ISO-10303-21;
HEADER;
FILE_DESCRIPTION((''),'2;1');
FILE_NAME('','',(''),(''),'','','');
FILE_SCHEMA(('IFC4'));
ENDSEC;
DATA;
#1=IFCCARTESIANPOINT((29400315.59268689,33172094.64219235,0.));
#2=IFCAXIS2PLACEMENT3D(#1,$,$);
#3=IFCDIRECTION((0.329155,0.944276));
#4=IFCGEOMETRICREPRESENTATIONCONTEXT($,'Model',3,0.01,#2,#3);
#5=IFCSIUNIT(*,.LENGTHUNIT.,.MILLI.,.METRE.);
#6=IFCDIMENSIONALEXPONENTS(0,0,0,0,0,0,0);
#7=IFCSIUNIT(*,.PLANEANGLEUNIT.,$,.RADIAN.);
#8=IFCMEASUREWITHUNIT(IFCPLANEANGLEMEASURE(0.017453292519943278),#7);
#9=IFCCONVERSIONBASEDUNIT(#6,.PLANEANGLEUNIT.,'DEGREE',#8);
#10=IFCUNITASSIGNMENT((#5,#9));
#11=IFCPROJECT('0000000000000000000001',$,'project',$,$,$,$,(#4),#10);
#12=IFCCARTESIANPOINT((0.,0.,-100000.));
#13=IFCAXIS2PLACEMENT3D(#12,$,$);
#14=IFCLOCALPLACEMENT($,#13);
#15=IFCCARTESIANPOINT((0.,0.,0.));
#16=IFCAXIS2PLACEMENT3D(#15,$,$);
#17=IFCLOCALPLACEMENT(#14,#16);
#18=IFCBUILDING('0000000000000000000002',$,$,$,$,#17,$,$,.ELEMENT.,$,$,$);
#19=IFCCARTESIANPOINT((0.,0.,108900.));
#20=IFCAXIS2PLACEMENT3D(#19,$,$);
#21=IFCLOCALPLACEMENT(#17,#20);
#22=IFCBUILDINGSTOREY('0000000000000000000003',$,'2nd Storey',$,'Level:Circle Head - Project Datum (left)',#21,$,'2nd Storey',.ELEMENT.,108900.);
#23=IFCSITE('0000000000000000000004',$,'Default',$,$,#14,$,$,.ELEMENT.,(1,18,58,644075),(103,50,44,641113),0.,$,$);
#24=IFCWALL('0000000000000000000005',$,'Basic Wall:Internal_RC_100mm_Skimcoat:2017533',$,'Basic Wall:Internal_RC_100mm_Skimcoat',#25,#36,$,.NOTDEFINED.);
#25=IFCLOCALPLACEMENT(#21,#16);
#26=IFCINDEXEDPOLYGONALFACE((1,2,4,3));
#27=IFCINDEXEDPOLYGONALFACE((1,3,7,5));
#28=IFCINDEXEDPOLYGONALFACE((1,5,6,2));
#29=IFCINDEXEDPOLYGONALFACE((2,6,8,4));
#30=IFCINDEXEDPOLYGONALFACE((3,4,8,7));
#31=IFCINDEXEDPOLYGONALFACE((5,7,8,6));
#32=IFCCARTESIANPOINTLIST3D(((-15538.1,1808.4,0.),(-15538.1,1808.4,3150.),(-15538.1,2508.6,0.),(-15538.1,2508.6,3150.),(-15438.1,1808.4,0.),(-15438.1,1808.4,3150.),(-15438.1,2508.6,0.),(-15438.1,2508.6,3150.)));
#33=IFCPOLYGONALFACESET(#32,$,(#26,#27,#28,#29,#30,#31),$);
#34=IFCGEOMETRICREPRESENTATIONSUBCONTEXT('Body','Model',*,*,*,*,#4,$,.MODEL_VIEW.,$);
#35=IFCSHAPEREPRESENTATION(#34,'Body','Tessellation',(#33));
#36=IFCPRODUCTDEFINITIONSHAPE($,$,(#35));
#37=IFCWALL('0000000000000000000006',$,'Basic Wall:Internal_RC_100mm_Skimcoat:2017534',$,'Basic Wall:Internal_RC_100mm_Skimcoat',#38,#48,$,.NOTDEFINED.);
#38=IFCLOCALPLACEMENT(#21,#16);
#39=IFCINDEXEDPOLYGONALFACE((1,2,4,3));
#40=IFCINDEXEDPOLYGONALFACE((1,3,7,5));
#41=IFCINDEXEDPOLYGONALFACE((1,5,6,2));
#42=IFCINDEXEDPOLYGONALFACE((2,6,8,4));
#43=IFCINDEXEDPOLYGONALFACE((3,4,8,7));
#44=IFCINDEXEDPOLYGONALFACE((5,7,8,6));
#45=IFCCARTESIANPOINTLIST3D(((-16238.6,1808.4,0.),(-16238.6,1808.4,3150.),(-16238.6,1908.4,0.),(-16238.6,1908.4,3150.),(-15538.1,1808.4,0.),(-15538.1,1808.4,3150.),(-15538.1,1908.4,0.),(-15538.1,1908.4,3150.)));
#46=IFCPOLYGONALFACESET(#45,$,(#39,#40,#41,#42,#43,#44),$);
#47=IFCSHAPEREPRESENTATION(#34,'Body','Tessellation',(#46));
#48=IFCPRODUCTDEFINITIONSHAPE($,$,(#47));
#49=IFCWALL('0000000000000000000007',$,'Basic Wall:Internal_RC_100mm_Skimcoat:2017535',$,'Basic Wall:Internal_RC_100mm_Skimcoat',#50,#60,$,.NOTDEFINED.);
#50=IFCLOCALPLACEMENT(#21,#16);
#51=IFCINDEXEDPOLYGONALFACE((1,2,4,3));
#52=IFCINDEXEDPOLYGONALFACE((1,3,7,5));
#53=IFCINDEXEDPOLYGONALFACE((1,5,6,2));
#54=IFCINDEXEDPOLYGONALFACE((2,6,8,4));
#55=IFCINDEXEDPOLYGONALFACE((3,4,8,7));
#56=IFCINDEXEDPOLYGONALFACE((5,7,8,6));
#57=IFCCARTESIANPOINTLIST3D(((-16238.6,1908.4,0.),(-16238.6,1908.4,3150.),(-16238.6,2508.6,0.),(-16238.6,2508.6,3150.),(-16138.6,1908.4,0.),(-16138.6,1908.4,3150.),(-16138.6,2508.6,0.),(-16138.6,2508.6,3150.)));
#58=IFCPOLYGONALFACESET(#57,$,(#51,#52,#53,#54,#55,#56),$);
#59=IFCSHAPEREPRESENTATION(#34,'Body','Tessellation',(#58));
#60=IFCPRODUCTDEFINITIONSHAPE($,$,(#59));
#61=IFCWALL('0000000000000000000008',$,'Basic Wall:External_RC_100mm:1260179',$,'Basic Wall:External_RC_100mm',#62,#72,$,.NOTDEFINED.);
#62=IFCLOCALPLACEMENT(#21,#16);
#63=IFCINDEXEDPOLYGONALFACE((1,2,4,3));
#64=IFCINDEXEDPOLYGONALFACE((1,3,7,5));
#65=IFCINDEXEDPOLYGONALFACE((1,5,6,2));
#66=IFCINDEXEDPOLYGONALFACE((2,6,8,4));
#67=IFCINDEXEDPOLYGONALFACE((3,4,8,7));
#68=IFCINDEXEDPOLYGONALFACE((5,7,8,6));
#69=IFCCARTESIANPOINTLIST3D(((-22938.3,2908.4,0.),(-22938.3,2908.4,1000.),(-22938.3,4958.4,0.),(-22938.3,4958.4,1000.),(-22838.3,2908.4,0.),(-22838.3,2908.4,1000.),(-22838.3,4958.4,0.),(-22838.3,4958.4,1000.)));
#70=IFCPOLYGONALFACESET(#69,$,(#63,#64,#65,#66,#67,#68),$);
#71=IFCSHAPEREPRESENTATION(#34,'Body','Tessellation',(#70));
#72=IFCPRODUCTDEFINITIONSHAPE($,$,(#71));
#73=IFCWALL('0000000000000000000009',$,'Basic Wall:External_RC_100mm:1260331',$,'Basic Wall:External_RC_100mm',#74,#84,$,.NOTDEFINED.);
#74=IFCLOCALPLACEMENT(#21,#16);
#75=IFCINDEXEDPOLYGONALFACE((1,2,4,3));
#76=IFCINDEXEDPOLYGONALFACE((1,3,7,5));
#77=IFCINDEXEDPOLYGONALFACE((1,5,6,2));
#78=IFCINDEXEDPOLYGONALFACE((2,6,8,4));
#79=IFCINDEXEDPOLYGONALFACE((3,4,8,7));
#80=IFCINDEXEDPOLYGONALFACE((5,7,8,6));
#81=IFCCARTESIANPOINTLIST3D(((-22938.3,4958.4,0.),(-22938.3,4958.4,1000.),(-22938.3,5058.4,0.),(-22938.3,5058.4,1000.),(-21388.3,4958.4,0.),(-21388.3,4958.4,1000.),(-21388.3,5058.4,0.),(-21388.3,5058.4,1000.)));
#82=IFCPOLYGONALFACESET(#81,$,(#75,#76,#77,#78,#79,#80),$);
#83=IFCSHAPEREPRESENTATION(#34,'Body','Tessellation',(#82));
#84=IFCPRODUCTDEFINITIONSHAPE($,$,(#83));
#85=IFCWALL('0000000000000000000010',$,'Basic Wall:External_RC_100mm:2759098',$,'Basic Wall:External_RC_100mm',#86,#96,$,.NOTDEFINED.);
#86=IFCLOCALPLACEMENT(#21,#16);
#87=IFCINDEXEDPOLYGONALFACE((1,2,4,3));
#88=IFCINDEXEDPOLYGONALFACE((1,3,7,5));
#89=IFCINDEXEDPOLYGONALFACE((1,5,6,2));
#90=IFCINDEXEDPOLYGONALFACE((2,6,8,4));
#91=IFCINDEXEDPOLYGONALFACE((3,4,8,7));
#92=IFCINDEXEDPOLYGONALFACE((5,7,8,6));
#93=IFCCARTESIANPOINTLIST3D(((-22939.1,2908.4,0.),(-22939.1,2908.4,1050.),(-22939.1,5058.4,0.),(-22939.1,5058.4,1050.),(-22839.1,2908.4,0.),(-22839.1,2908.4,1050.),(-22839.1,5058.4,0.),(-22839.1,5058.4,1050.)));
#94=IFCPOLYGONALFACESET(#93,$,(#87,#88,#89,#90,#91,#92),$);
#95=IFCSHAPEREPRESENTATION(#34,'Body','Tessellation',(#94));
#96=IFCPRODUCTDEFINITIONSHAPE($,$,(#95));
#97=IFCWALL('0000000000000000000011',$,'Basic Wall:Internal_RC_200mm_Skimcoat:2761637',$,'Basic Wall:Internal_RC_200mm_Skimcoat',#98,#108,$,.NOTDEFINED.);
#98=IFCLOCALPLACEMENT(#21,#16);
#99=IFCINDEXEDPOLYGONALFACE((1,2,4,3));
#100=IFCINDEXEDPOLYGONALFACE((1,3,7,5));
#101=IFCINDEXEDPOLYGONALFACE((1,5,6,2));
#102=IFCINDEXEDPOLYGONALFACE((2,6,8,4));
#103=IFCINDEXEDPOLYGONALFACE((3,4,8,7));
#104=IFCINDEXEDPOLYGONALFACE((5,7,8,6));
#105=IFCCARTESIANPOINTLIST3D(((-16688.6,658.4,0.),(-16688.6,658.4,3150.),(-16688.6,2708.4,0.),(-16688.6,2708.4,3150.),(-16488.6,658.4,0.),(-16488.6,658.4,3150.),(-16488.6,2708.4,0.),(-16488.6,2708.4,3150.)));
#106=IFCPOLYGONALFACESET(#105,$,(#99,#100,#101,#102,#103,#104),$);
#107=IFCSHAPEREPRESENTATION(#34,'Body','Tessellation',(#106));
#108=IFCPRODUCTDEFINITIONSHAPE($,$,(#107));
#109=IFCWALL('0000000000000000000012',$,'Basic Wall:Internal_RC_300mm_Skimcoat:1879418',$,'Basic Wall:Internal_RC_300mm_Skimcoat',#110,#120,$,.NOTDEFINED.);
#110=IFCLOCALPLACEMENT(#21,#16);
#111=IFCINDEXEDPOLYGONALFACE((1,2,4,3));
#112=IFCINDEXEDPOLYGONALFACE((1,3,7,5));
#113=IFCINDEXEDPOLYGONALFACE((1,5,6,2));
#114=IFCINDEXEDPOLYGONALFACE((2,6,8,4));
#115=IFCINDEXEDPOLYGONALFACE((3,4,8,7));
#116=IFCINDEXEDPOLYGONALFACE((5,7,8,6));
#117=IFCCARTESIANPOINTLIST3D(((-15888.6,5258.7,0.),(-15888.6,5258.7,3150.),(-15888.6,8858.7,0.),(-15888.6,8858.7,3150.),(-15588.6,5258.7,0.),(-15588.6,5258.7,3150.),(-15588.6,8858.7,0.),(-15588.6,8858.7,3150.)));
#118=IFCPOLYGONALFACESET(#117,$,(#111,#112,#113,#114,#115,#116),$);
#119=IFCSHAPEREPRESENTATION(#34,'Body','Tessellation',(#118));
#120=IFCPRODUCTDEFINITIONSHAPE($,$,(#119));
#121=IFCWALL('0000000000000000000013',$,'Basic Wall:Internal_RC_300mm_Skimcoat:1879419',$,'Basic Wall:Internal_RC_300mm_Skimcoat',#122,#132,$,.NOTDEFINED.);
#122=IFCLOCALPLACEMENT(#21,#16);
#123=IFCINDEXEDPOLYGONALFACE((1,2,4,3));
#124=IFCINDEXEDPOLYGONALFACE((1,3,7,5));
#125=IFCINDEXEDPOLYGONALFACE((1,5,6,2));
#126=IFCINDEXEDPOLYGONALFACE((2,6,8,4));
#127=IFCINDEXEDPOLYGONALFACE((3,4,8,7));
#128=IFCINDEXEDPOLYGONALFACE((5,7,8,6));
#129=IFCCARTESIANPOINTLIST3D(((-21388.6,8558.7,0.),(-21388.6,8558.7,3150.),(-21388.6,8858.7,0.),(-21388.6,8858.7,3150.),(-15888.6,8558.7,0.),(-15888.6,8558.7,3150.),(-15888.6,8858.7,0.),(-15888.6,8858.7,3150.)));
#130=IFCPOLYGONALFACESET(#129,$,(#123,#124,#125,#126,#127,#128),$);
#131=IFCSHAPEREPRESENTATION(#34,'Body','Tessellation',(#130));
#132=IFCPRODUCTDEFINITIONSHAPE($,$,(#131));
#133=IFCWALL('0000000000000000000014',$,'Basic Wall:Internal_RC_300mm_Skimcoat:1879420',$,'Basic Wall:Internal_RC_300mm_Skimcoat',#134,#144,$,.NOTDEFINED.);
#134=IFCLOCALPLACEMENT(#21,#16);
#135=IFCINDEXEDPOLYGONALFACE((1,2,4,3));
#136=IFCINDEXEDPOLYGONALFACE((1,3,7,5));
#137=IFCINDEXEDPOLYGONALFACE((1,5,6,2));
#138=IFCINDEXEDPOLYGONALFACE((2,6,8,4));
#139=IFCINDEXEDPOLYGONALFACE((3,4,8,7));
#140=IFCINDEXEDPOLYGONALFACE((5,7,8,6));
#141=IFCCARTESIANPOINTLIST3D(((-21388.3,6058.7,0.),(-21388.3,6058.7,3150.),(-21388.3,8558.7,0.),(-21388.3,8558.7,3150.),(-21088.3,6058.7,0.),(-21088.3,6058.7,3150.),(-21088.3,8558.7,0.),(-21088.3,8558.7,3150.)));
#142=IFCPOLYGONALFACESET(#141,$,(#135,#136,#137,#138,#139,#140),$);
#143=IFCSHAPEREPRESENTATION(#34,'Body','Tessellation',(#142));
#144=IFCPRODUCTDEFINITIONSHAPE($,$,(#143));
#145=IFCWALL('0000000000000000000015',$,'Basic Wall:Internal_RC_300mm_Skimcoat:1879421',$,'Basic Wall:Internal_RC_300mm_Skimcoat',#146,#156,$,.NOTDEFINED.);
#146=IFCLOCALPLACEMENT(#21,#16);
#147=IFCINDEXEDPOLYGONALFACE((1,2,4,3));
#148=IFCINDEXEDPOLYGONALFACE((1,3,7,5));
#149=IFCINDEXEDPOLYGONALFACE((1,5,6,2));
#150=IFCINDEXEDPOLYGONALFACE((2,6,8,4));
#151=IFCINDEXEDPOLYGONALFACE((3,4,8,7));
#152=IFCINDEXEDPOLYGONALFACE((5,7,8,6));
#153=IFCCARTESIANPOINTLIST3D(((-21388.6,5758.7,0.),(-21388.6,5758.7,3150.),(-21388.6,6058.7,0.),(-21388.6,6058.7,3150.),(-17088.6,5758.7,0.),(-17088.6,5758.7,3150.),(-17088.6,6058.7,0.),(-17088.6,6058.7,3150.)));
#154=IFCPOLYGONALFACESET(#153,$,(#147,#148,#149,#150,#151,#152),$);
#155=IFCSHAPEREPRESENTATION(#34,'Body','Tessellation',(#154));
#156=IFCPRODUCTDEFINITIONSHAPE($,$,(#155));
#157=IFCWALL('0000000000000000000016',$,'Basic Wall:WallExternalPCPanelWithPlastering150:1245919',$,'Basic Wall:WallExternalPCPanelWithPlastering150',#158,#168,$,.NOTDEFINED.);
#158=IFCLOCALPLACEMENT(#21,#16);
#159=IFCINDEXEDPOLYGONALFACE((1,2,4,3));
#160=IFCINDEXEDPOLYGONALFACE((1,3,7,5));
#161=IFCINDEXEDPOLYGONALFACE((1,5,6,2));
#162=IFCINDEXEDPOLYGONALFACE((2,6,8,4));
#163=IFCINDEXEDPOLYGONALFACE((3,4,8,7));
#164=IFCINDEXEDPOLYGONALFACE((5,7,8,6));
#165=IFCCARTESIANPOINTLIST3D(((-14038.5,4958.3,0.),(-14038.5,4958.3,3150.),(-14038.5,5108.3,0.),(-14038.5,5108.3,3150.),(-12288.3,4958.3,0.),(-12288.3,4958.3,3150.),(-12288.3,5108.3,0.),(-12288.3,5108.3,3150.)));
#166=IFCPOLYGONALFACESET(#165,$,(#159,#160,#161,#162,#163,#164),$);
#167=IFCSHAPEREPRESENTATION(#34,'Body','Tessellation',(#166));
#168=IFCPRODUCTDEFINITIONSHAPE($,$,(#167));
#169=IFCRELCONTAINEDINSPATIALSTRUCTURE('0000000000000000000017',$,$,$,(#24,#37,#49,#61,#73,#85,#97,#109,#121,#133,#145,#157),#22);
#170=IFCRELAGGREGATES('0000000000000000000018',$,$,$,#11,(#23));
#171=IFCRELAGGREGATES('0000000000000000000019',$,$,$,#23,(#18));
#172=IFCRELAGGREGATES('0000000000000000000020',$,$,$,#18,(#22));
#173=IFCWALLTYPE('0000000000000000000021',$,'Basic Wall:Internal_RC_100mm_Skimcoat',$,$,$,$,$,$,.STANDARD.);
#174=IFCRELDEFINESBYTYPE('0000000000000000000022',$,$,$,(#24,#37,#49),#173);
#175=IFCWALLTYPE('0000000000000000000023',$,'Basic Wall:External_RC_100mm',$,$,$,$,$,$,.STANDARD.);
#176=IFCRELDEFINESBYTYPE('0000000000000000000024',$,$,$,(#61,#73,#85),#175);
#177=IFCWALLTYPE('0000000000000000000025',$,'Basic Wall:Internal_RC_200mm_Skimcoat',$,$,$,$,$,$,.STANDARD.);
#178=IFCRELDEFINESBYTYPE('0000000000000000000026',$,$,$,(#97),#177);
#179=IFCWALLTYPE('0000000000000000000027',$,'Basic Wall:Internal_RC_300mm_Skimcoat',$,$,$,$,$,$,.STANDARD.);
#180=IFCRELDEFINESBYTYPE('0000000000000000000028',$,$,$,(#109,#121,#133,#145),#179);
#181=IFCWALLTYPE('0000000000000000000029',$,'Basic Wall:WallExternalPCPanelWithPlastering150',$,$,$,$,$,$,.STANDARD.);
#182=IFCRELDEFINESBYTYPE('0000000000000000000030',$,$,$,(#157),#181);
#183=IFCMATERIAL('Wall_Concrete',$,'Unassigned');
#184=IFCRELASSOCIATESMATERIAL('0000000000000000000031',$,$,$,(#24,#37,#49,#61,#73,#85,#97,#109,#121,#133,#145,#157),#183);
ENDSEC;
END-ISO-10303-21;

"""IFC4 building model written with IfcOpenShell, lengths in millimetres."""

from ifc_helpers import new_model, entity, si_unit, converted_unit, direction, frame, origin, place, context, subcontext, project, spatial, indexed_curve, outline, extrude, material, type_object, element, save


model = new_model("IFC4")

# Units and contexts
model_context = context("Model", 3, precision=0.01, world=frame((29400315.59268689, 33172094.64219235, 0.0)), true_north=direction((0.329155, 0.944276)))
body_context = subcontext(model_context, "Body", "Model", "MODEL_VIEW")
ifc_project = project(units=[si_unit("LENGTHUNIT", "METRE", prefix="MILLI"), converted_unit("PLANEANGLEUNIT", "DEGREE", entity("IfcPlaneAngleMeasure", 0.017453292519943278), si_unit("PLANEANGLEUNIT", "RADIAN"), dimensions=[0, 0, 0, 0, 0, 0, 0])], contexts=[model_context])

# Site, building, storey
site_placement = place(None, frame((0.0, 0.0, -100000.0)))
site = spatial("IfcSite", under=ifc_project, at=site_placement, Name="Default", CompositionType="ELEMENT", RefLatitude=(1, 18, 58, 644075), RefLongitude=(103, 50, 44, 641113), RefElevation=0.0)
building_placement = place(site_placement, origin())
building = spatial("IfcBuilding", under=site, at=building_placement, CompositionType="ELEMENT")
storey_placement = place(building_placement, frame((0.0, 0.0, 108900.0)))
storey = spatial("IfcBuildingStorey", under=building, at=storey_placement, Name="2nd Storey", ObjectType="Level:Circle Head - Project Datum (left)", LongName="2nd Storey", CompositionType="ELEMENT", Elevation=108900.0)

# Walls
ifc_material_1 = material(Name="Wall_Concrete", Category="Unassigned")
wall_type_1 = type_object("IfcWallType", Name="Basic Wall:Internal_RC_100mm_Skimcoat", PredefinedType="STANDARD")
wall_1_placement = place(storey_placement, frame((-15488.1, 2508.6, 0.0), z_axis=(0.0, 0.0, 1.0), x_axis=(0.0, -1.0, 0.0)))
element("IfcWall", 1, at=wall_1_placement, inside=storey, type_object=wall_type_1, material=ifc_material_1, Name="Basic Wall:Internal_RC_100mm_Skimcoat:2017533", ObjectType="Basic Wall:Internal_RC_100mm_Skimcoat", PredefinedType="NOTDEFINED", context=body_context, shape_type="SweptSolid", body=[
    extrude(outline(indexed_curve([(700.1, 50.0), (0.0, 50.0), (0.0, -50.0), (700.1, -50.0), (700.1, 50.0)], self_intersect=False)), origin(), (0.0, 0.0, 1.0), 3150.0),
])
wall_2_placement = place(storey_placement, frame((-15538.1, 1858.4, 0.0), z_axis=(0.0, 0.0, 1.0), x_axis=(-1.0, 0.0, 0.0)))
element("IfcWall", 2, at=wall_2_placement, inside=storey, type_object=wall_type_1, material=ifc_material_1, Name="Basic Wall:Internal_RC_100mm_Skimcoat:2017534", ObjectType="Basic Wall:Internal_RC_100mm_Skimcoat", PredefinedType="NOTDEFINED", context=body_context, shape_type="SweptSolid", body=[
    extrude(outline(indexed_curve([(700.5, 50.0), (0.0, 50.0), (0.0, -50.0), (700.5, -50.0), (700.5, 50.0)], self_intersect=False)), origin(), (0.0, 0.0, 1.0), 3150.0),
])
wall_3_placement = place(storey_placement, frame((-16188.6, 2508.6, 0.0), z_axis=(0.0, 0.0, 1.0), x_axis=(0.0, -1.0, 0.0)))
element("IfcWall", 3, at=wall_3_placement, inside=storey, type_object=wall_type_1, material=ifc_material_1, Name="Basic Wall:Internal_RC_100mm_Skimcoat:2017535", ObjectType="Basic Wall:Internal_RC_100mm_Skimcoat", PredefinedType="NOTDEFINED", context=body_context, shape_type="SweptSolid", body=[
    extrude(outline(indexed_curve([(600.1, 50.0), (0.0, 50.0), (0.0, -50.0), (600.1, -50.0), (600.1, 50.0)], self_intersect=False)), origin(), (0.0, 0.0, 1.0), 3150.0),
])
wall_type_2 = type_object("IfcWallType", Name="Basic Wall:External_RC_100mm", PredefinedType="STANDARD")
wall_4_placement = place(storey_placement, frame((-22888.3, 4958.4, 0.0), z_axis=(0.0, 0.0, 1.0), x_axis=(0.0, -1.0, 0.0)))
element("IfcWall", 4, at=wall_4_placement, inside=storey, type_object=wall_type_2, material=ifc_material_1, Name="Basic Wall:External_RC_100mm:1260179", ObjectType="Basic Wall:External_RC_100mm", PredefinedType="NOTDEFINED", context=body_context, shape_type="SweptSolid", body=[
    extrude(outline(indexed_curve([(2050.0, 50.0), (0.0, 50.0), (0.0, -50.0), (2050.0, -50.0), (2050.0, 50.0)], self_intersect=False)), origin(), (0.0, 0.0, 1.0), 1000.0),
])
wall_5_placement = place(storey_placement, frame((-22938.3, 5008.4, 0.0)))
element("IfcWall", 5, at=wall_5_placement, inside=storey, type_object=wall_type_2, material=ifc_material_1, Name="Basic Wall:External_RC_100mm:1260331", ObjectType="Basic Wall:External_RC_100mm", PredefinedType="NOTDEFINED", context=body_context, shape_type="SweptSolid", body=[
    extrude(outline(indexed_curve([(1550.0, 50.0), (0.0, 50.0), (0.0, -50.0), (1550.0, -50.0), (1550.0, 50.0)], self_intersect=False)), origin(), (0.0, 0.0, 1.0), 1000.0),
])
wall_6_placement = place(storey_placement, frame((-22889.1, 5058.4, 0.0), z_axis=(0.0, 0.0, 1.0), x_axis=(0.0, -1.0, 0.0)))
element("IfcWall", 6, at=wall_6_placement, inside=storey, type_object=wall_type_2, material=ifc_material_1, Name="Basic Wall:External_RC_100mm:2759098", ObjectType="Basic Wall:External_RC_100mm", PredefinedType="NOTDEFINED", context=body_context, shape_type="SweptSolid", body=[
    extrude(outline(indexed_curve([(2150.0, 50.0), (0.0, 50.0), (0.0, -50.0), (2150.0, -50.0), (2150.0, 50.0)], self_intersect=False)), origin(), (0.0, 0.0, 1.0), 1050.0),
])
wall_type_3 = type_object("IfcWallType", Name="Basic Wall:Internal_RC_200mm_Skimcoat", PredefinedType="STANDARD")
wall_7_placement = place(storey_placement, frame((-16588.6, 658.4, 0.0), z_axis=(0.0, 0.0, 1.0), x_axis=(0.0, 1.0, 0.0)))
element("IfcWall", 7, at=wall_7_placement, inside=storey, type_object=wall_type_3, material=ifc_material_1, Name="Basic Wall:Internal_RC_200mm_Skimcoat:2761637", ObjectType="Basic Wall:Internal_RC_200mm_Skimcoat", PredefinedType="NOTDEFINED", context=body_context, shape_type="SweptSolid", body=[
    extrude(outline(indexed_curve([(2050.0, 100.0), (0.0, 100.0), (0.0, -100.0), (2050.0, -100.0), (2050.0, 100.0)], self_intersect=False)), origin(), (0.0, 0.0, 1.0), 3150.0),
])
wall_type_4 = type_object("IfcWallType", Name="Basic Wall:Internal_RC_300mm_Skimcoat", PredefinedType="STANDARD")
wall_8_placement = place(storey_placement, frame((-15738.6, 8858.7, 0.0), z_axis=(0.0, 0.0, 1.0), x_axis=(0.0, -1.0, 0.0)))
element("IfcWall", 8, at=wall_8_placement, inside=storey, type_object=wall_type_4, material=ifc_material_1, Name="Basic Wall:Internal_RC_300mm_Skimcoat:1879418", ObjectType="Basic Wall:Internal_RC_300mm_Skimcoat", PredefinedType="NOTDEFINED", context=body_context, shape_type="SweptSolid", body=[
    extrude(outline(indexed_curve([(3600.0, 150.0), (0.0, 150.0), (0.0, -150.0), (3600.0, -150.0), (3600.0, 150.0)], self_intersect=False)), origin(), (0.0, 0.0, 1.0), 3150.0),
])
wall_9_placement = place(storey_placement, frame((-15888.6, 8708.7, 0.0), z_axis=(0.0, 0.0, 1.0), x_axis=(-1.0, 0.0, 0.0)))
element("IfcWall", 9, at=wall_9_placement, inside=storey, type_object=wall_type_4, material=ifc_material_1, Name="Basic Wall:Internal_RC_300mm_Skimcoat:1879419", ObjectType="Basic Wall:Internal_RC_300mm_Skimcoat", PredefinedType="NOTDEFINED", context=body_context, shape_type="SweptSolid", body=[
    extrude(outline(indexed_curve([(5500.0, 150.0), (0.0, 150.0), (0.0, -150.0), (5500.0, -150.0), (5500.0, 150.0)], self_intersect=False)), origin(), (0.0, 0.0, 1.0), 3150.0),
])
wall_10_placement = place(storey_placement, frame((-21238.3, 8558.7, 0.0), z_axis=(0.0, 0.0, 1.0), x_axis=(0.0, -1.0, 0.0)))
element("IfcWall", 10, at=wall_10_placement, inside=storey, type_object=wall_type_4, material=ifc_material_1, Name="Basic Wall:Internal_RC_300mm_Skimcoat:1879420", ObjectType="Basic Wall:Internal_RC_300mm_Skimcoat", PredefinedType="NOTDEFINED", context=body_context, shape_type="SweptSolid", body=[
    extrude(outline(indexed_curve([(2500.0, 150.0), (0.0, 150.0), (0.0, -150.0), (2500.0, -150.0), (2500.0, 150.0)], self_intersect=False)), origin(), (0.0, 0.0, 1.0), 3150.0),
])
wall_11_placement = place(storey_placement, frame((-21388.6, 5908.7, 0.0)))
element("IfcWall", 11, at=wall_11_placement, inside=storey, type_object=wall_type_4, material=ifc_material_1, Name="Basic Wall:Internal_RC_300mm_Skimcoat:1879421", ObjectType="Basic Wall:Internal_RC_300mm_Skimcoat", PredefinedType="NOTDEFINED", context=body_context, shape_type="SweptSolid", body=[
    extrude(outline(indexed_curve([(4300.0, 150.0), (0.0, 150.0), (0.0, -150.0), (4300.0, -150.0), (4300.0, 150.0)], self_intersect=False)), origin(), (0.0, 0.0, 1.0), 3150.0),
])
wall_type_5 = type_object("IfcWallType", Name="Basic Wall:WallExternalPCPanelWithPlastering150", PredefinedType="STANDARD")
wall_12_placement = place(storey_placement, frame((-14038.5, 5033.3, 0.0)))
element("IfcWall", 12, at=wall_12_placement, inside=storey, type_object=wall_type_5, material=ifc_material_1, Name="Basic Wall:WallExternalPCPanelWithPlastering150:1245919", ObjectType="Basic Wall:WallExternalPCPanelWithPlastering150", PredefinedType="NOTDEFINED", context=body_context, shape_type="SweptSolid", body=[
    extrude(outline(indexed_curve([(1750.1, 75.0), (0.0, 75.0), (0.0, -75.0), (1750.1, -75.0), (1750.1, 75.0)], self_intersect=False)), origin(), (0.0, 0.0, 1.0), 3150.0),
])

save(model, "model.ifc")
